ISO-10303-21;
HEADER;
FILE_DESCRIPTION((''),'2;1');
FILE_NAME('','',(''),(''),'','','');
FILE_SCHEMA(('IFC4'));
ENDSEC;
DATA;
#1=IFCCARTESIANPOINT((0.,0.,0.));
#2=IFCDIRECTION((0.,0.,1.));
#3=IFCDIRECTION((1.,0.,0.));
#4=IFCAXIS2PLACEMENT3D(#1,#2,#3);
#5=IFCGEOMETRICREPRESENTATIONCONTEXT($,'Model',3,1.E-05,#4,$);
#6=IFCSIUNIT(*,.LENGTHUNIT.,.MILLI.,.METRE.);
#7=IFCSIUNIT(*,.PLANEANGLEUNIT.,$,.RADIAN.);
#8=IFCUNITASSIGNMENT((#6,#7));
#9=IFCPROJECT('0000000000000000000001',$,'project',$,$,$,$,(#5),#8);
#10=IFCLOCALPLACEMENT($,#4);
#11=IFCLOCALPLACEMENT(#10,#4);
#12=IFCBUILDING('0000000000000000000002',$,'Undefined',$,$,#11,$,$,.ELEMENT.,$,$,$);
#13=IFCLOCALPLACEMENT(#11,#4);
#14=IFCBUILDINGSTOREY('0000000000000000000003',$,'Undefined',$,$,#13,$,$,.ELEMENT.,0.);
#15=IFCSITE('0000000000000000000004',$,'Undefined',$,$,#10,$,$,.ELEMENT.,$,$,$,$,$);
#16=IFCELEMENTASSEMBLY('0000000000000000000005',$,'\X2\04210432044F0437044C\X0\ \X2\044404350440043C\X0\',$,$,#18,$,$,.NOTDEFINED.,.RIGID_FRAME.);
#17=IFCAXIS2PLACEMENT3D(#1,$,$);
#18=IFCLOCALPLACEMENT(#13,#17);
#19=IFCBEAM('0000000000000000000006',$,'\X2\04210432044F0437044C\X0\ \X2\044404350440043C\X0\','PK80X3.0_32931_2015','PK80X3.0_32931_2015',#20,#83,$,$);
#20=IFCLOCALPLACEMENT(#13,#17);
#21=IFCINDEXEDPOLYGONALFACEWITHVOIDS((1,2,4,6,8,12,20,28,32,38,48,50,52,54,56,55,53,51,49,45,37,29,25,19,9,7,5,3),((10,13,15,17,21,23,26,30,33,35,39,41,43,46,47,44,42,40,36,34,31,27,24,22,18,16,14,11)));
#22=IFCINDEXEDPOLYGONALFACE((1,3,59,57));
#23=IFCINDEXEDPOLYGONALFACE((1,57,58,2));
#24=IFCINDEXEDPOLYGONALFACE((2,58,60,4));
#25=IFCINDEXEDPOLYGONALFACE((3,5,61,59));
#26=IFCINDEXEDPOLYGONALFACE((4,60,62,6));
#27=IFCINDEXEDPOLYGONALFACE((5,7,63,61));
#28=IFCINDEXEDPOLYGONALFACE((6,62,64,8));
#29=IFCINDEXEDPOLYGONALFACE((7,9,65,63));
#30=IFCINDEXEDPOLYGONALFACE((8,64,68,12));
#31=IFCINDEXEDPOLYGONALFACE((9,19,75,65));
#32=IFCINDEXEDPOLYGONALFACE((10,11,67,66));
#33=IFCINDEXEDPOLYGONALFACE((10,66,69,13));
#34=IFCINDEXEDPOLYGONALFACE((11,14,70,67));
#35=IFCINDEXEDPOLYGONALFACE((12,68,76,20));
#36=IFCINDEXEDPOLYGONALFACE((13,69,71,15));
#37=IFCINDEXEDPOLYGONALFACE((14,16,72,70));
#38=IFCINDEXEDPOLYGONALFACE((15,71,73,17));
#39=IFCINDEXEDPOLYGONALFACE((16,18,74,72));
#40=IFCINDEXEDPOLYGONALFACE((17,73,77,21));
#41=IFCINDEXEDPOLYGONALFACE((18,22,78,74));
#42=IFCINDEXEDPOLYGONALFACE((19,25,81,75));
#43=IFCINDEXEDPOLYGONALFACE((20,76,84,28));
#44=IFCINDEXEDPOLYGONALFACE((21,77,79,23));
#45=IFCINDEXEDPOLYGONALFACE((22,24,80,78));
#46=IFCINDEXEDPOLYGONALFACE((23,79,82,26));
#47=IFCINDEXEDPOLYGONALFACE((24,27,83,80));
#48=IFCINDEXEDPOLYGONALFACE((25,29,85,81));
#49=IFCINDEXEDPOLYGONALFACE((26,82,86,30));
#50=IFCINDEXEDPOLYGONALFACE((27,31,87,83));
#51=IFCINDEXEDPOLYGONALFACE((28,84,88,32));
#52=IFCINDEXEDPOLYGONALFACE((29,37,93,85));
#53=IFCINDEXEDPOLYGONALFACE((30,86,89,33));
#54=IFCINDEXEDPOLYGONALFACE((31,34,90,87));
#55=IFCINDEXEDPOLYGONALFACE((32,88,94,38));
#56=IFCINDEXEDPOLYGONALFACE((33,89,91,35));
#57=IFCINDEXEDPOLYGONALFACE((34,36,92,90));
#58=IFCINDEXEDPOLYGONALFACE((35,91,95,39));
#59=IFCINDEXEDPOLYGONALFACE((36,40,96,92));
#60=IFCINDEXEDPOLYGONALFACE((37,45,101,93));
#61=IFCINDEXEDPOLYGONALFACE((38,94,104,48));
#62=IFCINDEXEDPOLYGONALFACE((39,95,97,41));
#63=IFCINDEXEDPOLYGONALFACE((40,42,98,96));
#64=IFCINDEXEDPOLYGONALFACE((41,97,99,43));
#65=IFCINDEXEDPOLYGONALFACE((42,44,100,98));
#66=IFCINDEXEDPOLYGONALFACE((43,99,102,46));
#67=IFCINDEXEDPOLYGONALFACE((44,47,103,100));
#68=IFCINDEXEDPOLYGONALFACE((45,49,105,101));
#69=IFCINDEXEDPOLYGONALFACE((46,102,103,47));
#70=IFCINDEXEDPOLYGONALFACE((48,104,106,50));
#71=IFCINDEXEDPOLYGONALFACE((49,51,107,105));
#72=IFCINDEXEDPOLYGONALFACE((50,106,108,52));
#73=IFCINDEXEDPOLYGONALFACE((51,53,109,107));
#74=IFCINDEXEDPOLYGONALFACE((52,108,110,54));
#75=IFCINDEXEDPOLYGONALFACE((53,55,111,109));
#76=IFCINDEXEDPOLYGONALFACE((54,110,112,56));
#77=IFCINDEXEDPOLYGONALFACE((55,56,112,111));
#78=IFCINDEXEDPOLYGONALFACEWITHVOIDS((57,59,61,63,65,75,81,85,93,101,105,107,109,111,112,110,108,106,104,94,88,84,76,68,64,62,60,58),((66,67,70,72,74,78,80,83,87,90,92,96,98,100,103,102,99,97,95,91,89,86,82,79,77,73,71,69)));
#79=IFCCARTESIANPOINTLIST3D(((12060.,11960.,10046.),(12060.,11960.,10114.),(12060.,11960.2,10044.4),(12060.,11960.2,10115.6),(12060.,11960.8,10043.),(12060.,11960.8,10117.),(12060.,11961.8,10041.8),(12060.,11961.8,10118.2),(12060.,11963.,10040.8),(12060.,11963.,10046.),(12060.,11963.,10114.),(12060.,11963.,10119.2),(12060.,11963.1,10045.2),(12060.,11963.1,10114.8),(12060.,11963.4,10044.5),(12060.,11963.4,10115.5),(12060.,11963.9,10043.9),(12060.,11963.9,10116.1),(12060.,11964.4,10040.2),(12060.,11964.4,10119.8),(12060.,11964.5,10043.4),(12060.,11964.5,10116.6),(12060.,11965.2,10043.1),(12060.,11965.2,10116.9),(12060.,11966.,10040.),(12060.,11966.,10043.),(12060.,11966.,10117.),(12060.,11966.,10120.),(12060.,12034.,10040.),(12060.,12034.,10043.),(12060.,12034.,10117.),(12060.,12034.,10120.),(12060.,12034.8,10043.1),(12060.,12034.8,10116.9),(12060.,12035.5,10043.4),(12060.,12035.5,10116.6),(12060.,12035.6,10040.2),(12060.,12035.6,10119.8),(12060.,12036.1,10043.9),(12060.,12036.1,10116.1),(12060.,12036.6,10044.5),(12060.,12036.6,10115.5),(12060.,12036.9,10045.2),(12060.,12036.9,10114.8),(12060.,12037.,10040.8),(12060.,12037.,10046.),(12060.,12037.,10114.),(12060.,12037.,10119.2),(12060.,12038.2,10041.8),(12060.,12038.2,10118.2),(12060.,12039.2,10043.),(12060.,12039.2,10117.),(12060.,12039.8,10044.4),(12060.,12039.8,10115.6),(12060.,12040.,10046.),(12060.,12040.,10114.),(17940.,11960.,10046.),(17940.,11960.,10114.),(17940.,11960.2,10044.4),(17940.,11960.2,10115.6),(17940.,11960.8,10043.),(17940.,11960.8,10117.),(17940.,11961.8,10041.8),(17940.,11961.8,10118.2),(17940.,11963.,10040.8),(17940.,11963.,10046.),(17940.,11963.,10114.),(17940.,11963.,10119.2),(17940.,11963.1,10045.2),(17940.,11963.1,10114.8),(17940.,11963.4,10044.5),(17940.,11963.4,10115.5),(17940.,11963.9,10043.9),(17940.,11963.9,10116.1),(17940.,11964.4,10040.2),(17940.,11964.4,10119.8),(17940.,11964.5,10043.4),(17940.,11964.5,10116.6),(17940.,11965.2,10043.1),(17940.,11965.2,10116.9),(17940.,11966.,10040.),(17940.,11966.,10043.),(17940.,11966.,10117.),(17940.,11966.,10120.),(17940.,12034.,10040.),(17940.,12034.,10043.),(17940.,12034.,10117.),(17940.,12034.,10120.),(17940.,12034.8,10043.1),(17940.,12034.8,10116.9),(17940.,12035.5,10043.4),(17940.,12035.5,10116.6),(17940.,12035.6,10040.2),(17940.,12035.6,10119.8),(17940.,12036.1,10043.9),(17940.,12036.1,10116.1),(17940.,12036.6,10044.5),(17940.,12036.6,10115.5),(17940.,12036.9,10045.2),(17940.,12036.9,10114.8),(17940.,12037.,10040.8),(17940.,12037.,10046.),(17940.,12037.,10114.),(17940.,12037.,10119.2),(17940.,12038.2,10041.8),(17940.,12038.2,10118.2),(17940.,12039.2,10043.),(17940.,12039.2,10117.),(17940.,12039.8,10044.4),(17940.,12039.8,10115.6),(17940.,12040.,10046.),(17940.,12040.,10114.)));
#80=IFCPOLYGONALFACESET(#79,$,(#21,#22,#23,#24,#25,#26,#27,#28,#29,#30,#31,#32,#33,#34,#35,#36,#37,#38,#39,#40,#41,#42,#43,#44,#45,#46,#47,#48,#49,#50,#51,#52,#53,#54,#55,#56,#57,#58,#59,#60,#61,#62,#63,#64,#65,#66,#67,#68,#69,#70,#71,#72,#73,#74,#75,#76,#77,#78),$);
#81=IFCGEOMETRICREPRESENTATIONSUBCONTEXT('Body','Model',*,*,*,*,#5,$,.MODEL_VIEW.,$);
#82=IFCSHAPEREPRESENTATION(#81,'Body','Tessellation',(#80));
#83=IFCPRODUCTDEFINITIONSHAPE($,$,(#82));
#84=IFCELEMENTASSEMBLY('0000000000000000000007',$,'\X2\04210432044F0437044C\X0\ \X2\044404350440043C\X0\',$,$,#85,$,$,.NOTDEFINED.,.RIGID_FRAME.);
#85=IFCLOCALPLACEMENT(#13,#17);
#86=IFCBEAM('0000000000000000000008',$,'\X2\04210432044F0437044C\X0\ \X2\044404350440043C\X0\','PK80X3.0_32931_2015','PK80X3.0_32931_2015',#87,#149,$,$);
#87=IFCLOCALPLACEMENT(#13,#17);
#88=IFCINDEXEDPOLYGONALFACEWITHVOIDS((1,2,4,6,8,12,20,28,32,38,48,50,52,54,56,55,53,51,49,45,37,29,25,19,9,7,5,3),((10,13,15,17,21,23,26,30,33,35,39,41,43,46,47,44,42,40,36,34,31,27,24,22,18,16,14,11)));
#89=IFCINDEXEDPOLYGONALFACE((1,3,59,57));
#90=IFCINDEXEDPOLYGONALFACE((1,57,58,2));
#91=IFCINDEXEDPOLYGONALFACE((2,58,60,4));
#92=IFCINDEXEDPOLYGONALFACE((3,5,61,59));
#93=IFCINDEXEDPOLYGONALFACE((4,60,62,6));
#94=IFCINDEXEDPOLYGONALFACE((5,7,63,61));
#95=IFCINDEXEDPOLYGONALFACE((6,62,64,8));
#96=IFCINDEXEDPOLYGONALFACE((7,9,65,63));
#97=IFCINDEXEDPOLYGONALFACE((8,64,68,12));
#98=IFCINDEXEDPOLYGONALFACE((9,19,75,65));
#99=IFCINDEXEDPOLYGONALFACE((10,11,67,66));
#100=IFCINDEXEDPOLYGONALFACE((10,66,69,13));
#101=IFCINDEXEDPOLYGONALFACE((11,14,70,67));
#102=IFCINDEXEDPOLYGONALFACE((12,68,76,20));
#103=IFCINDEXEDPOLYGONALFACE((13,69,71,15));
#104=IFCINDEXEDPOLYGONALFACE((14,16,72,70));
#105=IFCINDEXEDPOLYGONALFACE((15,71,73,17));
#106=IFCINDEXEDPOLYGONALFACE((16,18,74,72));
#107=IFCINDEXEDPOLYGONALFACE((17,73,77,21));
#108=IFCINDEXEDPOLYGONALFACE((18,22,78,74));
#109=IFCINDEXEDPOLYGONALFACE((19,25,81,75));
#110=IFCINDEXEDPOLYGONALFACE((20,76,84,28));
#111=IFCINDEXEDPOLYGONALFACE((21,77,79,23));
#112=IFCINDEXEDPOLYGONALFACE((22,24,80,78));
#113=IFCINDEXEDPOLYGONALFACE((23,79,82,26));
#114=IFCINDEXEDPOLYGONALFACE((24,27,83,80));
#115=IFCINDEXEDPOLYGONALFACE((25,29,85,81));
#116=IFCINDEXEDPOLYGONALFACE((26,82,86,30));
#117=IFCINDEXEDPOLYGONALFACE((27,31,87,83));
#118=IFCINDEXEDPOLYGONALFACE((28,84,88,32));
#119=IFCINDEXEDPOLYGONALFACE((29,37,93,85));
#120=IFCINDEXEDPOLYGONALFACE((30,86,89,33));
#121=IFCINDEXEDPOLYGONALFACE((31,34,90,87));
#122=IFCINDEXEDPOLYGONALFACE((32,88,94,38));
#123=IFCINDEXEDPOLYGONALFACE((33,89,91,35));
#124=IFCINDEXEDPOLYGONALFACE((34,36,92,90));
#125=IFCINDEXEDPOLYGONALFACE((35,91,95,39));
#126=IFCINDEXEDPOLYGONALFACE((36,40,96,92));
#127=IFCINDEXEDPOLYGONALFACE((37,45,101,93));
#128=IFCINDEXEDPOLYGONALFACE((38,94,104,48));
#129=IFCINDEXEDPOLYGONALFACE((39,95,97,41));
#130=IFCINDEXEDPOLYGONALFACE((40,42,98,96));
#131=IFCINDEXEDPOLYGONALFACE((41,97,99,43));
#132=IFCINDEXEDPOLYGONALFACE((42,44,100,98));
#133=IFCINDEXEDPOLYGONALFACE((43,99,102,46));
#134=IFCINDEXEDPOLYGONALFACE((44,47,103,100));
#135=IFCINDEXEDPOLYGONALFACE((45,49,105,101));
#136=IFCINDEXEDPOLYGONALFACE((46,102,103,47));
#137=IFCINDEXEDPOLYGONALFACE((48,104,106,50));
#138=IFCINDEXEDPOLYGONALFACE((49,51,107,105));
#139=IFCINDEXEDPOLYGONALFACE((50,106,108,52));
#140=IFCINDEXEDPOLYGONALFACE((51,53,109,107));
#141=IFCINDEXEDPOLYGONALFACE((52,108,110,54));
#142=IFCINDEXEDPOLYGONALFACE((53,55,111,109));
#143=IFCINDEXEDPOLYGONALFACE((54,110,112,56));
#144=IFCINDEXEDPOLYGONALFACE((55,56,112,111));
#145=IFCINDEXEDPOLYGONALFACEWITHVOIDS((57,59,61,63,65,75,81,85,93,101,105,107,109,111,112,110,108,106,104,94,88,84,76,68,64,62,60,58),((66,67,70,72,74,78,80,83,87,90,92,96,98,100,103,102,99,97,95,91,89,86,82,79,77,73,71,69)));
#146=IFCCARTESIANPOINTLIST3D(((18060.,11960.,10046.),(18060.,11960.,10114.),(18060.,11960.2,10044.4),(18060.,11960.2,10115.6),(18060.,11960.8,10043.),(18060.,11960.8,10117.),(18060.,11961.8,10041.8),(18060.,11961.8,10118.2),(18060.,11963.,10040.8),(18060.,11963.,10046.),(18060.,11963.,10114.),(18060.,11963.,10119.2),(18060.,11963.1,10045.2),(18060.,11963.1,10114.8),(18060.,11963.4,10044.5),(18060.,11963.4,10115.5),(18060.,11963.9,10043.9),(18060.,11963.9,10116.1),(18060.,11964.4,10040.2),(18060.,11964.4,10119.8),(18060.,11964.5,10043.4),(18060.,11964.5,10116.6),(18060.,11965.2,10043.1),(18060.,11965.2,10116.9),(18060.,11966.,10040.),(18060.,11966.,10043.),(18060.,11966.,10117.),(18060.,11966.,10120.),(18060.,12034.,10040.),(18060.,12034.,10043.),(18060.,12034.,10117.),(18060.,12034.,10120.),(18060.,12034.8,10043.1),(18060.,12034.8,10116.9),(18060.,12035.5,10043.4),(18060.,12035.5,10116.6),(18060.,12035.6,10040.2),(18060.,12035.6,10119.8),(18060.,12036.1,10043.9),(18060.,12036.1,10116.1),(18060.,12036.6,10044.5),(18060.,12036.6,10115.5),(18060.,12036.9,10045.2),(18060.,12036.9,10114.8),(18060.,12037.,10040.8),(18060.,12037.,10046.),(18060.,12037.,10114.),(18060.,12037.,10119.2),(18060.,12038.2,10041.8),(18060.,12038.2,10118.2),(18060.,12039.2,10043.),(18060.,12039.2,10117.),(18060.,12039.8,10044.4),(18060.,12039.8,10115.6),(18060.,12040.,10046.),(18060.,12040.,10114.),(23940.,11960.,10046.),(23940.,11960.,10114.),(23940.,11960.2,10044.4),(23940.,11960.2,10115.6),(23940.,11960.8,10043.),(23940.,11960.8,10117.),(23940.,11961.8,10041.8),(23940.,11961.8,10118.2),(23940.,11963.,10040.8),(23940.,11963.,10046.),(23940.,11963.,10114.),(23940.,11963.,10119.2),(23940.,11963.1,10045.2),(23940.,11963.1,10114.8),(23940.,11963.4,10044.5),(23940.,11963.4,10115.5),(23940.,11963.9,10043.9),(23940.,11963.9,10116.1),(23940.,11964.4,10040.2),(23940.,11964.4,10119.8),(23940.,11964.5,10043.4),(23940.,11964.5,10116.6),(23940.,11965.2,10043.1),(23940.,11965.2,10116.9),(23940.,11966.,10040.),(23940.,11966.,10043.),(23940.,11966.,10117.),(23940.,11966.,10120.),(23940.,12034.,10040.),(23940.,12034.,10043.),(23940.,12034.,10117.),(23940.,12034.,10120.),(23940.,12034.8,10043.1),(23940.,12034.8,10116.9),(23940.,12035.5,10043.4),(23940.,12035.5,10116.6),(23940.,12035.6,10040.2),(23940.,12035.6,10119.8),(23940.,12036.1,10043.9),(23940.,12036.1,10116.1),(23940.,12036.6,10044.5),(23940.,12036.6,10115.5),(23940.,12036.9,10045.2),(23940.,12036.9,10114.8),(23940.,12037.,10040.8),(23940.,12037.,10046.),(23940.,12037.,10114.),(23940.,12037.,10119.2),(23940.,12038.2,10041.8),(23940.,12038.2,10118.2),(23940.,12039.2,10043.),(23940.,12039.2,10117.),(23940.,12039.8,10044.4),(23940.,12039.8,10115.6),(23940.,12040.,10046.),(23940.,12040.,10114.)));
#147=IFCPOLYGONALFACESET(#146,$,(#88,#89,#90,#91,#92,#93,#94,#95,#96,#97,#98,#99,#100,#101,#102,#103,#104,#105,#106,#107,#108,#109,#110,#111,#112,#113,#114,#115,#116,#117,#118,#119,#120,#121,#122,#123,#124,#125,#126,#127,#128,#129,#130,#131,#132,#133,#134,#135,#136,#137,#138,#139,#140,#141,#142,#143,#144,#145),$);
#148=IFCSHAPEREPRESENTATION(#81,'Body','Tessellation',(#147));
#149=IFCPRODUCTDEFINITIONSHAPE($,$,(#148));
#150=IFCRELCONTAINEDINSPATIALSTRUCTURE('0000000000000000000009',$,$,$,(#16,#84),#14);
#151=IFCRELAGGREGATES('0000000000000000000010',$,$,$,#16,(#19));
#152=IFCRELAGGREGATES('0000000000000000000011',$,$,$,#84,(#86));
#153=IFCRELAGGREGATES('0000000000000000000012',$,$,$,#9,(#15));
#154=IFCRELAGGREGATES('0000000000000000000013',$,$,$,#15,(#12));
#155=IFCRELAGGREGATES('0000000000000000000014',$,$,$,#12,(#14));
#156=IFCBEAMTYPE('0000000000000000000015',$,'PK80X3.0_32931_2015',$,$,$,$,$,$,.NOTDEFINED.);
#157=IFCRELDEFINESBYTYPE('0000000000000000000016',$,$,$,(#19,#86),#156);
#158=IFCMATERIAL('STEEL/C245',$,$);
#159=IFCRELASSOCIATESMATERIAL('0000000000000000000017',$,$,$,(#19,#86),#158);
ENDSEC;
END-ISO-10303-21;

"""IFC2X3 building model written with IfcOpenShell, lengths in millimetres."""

from ifc_helpers import new_model, si_unit, frame, origin_with_axes, origin_2d_with_axis, place, context, subcontext, project, spatial, hollow_rectangle, extrude, material, type_object, element, aggregate, save


model = new_model("IFC2X3")

# Units and contexts
model_context = context("Model", 3, precision=1e-05, world=origin_with_axes())
body_context = subcontext(model_context, "Body", "Model", "MODEL_VIEW")
ifc_project = project(units=[si_unit("LENGTHUNIT", "METRE", prefix="MILLI"), si_unit("PLANEANGLEUNIT", "RADIAN")], contexts=[model_context])

# Site, building, storey
site_placement = place(None, origin_with_axes())
site = spatial("IfcSite", under=ifc_project, at=site_placement, Name="Undefined", CompositionType="ELEMENT")
building_placement = place(site_placement, origin_with_axes())
building = spatial("IfcBuilding", under=site, at=building_placement, Name="Undefined", CompositionType="ELEMENT")
storey_placement = place(building_placement, origin_with_axes())
storey = spatial("IfcBuildingStorey", under=building, at=storey_placement, Name="Undefined", CompositionType="ELEMENT", Elevation=0.0)

# Shared definitions
ifc_material_1 = material(Name="STEEL/C245")

# Element assemblies, beams
assembly_1_placement = place(storey_placement, origin_with_axes())
assembly_1 = element("IfcElementAssembly", 1, at=assembly_1_placement, inside=storey, Name="Связь ферм", AssemblyPlace="NOTDEFINED", PredefinedType="RIGID_FRAME")
beam_type_1 = type_object("IfcBeamType", Name="PK80X3.0_32931_2015", PredefinedType="NOTDEFINED")
beam_1_placement = place(assembly_1_placement, frame((12060.0, 12000.0, 10080.0), z_axis=(0.0, 0.0, 1.0), x_axis=(1.0, 0.0, 0.0)))
beam_1 = element("IfcBeam", 2, at=beam_1_placement, type_object=beam_type_1, material=ifc_material_1, Name="Связь ферм", Description="PK80X3.0_32931_2015", ObjectType="PK80X3.0_32931_2015", context=body_context, shape_type="SweptSolid", body=[
    extrude(hollow_rectangle(XDim=80.0, YDim=80.0, WallThickness=3.0, InnerFilletRadius=3.0, OuterFilletRadius=6.0, at=origin_2d_with_axis()), frame((5880.0, 0.0, 0.0), z_axis=(-1.0, 0.0, 0.0), x_axis=(0.0, -1.0, 0.0)), (0.0, 0.0, 1.0), 5880.0),
])
aggregate(assembly_1, [beam_1])
assembly_2_placement = place(storey_placement, origin_with_axes())
assembly_2 = element("IfcElementAssembly", 3, at=assembly_2_placement, inside=storey, Name="Связь ферм", AssemblyPlace="NOTDEFINED", PredefinedType="RIGID_FRAME")
beam_2_placement = place(assembly_2_placement, frame((18060.0, 12000.0, 10080.0), z_axis=(0.0, 0.0, 1.0), x_axis=(1.0, 0.0, 0.0)))
beam_2 = element("IfcBeam", 4, at=beam_2_placement, type_object=beam_type_1, material=ifc_material_1, Name="Связь ферм", Description="PK80X3.0_32931_2015", ObjectType="PK80X3.0_32931_2015", context=body_context, shape_type="SweptSolid", body=[
    extrude(hollow_rectangle(XDim=80.0, YDim=80.0, WallThickness=3.0, InnerFilletRadius=3.0, OuterFilletRadius=6.0, at=origin_2d_with_axis()), frame((5880.0, 0.0, 0.0), z_axis=(-1.0, 0.0, 0.0), x_axis=(0.0, -1.0, 0.0)), (0.0, 0.0, 1.0), 5880.0),
])
aggregate(assembly_2, [beam_2])

save(model, "model.ifc")
